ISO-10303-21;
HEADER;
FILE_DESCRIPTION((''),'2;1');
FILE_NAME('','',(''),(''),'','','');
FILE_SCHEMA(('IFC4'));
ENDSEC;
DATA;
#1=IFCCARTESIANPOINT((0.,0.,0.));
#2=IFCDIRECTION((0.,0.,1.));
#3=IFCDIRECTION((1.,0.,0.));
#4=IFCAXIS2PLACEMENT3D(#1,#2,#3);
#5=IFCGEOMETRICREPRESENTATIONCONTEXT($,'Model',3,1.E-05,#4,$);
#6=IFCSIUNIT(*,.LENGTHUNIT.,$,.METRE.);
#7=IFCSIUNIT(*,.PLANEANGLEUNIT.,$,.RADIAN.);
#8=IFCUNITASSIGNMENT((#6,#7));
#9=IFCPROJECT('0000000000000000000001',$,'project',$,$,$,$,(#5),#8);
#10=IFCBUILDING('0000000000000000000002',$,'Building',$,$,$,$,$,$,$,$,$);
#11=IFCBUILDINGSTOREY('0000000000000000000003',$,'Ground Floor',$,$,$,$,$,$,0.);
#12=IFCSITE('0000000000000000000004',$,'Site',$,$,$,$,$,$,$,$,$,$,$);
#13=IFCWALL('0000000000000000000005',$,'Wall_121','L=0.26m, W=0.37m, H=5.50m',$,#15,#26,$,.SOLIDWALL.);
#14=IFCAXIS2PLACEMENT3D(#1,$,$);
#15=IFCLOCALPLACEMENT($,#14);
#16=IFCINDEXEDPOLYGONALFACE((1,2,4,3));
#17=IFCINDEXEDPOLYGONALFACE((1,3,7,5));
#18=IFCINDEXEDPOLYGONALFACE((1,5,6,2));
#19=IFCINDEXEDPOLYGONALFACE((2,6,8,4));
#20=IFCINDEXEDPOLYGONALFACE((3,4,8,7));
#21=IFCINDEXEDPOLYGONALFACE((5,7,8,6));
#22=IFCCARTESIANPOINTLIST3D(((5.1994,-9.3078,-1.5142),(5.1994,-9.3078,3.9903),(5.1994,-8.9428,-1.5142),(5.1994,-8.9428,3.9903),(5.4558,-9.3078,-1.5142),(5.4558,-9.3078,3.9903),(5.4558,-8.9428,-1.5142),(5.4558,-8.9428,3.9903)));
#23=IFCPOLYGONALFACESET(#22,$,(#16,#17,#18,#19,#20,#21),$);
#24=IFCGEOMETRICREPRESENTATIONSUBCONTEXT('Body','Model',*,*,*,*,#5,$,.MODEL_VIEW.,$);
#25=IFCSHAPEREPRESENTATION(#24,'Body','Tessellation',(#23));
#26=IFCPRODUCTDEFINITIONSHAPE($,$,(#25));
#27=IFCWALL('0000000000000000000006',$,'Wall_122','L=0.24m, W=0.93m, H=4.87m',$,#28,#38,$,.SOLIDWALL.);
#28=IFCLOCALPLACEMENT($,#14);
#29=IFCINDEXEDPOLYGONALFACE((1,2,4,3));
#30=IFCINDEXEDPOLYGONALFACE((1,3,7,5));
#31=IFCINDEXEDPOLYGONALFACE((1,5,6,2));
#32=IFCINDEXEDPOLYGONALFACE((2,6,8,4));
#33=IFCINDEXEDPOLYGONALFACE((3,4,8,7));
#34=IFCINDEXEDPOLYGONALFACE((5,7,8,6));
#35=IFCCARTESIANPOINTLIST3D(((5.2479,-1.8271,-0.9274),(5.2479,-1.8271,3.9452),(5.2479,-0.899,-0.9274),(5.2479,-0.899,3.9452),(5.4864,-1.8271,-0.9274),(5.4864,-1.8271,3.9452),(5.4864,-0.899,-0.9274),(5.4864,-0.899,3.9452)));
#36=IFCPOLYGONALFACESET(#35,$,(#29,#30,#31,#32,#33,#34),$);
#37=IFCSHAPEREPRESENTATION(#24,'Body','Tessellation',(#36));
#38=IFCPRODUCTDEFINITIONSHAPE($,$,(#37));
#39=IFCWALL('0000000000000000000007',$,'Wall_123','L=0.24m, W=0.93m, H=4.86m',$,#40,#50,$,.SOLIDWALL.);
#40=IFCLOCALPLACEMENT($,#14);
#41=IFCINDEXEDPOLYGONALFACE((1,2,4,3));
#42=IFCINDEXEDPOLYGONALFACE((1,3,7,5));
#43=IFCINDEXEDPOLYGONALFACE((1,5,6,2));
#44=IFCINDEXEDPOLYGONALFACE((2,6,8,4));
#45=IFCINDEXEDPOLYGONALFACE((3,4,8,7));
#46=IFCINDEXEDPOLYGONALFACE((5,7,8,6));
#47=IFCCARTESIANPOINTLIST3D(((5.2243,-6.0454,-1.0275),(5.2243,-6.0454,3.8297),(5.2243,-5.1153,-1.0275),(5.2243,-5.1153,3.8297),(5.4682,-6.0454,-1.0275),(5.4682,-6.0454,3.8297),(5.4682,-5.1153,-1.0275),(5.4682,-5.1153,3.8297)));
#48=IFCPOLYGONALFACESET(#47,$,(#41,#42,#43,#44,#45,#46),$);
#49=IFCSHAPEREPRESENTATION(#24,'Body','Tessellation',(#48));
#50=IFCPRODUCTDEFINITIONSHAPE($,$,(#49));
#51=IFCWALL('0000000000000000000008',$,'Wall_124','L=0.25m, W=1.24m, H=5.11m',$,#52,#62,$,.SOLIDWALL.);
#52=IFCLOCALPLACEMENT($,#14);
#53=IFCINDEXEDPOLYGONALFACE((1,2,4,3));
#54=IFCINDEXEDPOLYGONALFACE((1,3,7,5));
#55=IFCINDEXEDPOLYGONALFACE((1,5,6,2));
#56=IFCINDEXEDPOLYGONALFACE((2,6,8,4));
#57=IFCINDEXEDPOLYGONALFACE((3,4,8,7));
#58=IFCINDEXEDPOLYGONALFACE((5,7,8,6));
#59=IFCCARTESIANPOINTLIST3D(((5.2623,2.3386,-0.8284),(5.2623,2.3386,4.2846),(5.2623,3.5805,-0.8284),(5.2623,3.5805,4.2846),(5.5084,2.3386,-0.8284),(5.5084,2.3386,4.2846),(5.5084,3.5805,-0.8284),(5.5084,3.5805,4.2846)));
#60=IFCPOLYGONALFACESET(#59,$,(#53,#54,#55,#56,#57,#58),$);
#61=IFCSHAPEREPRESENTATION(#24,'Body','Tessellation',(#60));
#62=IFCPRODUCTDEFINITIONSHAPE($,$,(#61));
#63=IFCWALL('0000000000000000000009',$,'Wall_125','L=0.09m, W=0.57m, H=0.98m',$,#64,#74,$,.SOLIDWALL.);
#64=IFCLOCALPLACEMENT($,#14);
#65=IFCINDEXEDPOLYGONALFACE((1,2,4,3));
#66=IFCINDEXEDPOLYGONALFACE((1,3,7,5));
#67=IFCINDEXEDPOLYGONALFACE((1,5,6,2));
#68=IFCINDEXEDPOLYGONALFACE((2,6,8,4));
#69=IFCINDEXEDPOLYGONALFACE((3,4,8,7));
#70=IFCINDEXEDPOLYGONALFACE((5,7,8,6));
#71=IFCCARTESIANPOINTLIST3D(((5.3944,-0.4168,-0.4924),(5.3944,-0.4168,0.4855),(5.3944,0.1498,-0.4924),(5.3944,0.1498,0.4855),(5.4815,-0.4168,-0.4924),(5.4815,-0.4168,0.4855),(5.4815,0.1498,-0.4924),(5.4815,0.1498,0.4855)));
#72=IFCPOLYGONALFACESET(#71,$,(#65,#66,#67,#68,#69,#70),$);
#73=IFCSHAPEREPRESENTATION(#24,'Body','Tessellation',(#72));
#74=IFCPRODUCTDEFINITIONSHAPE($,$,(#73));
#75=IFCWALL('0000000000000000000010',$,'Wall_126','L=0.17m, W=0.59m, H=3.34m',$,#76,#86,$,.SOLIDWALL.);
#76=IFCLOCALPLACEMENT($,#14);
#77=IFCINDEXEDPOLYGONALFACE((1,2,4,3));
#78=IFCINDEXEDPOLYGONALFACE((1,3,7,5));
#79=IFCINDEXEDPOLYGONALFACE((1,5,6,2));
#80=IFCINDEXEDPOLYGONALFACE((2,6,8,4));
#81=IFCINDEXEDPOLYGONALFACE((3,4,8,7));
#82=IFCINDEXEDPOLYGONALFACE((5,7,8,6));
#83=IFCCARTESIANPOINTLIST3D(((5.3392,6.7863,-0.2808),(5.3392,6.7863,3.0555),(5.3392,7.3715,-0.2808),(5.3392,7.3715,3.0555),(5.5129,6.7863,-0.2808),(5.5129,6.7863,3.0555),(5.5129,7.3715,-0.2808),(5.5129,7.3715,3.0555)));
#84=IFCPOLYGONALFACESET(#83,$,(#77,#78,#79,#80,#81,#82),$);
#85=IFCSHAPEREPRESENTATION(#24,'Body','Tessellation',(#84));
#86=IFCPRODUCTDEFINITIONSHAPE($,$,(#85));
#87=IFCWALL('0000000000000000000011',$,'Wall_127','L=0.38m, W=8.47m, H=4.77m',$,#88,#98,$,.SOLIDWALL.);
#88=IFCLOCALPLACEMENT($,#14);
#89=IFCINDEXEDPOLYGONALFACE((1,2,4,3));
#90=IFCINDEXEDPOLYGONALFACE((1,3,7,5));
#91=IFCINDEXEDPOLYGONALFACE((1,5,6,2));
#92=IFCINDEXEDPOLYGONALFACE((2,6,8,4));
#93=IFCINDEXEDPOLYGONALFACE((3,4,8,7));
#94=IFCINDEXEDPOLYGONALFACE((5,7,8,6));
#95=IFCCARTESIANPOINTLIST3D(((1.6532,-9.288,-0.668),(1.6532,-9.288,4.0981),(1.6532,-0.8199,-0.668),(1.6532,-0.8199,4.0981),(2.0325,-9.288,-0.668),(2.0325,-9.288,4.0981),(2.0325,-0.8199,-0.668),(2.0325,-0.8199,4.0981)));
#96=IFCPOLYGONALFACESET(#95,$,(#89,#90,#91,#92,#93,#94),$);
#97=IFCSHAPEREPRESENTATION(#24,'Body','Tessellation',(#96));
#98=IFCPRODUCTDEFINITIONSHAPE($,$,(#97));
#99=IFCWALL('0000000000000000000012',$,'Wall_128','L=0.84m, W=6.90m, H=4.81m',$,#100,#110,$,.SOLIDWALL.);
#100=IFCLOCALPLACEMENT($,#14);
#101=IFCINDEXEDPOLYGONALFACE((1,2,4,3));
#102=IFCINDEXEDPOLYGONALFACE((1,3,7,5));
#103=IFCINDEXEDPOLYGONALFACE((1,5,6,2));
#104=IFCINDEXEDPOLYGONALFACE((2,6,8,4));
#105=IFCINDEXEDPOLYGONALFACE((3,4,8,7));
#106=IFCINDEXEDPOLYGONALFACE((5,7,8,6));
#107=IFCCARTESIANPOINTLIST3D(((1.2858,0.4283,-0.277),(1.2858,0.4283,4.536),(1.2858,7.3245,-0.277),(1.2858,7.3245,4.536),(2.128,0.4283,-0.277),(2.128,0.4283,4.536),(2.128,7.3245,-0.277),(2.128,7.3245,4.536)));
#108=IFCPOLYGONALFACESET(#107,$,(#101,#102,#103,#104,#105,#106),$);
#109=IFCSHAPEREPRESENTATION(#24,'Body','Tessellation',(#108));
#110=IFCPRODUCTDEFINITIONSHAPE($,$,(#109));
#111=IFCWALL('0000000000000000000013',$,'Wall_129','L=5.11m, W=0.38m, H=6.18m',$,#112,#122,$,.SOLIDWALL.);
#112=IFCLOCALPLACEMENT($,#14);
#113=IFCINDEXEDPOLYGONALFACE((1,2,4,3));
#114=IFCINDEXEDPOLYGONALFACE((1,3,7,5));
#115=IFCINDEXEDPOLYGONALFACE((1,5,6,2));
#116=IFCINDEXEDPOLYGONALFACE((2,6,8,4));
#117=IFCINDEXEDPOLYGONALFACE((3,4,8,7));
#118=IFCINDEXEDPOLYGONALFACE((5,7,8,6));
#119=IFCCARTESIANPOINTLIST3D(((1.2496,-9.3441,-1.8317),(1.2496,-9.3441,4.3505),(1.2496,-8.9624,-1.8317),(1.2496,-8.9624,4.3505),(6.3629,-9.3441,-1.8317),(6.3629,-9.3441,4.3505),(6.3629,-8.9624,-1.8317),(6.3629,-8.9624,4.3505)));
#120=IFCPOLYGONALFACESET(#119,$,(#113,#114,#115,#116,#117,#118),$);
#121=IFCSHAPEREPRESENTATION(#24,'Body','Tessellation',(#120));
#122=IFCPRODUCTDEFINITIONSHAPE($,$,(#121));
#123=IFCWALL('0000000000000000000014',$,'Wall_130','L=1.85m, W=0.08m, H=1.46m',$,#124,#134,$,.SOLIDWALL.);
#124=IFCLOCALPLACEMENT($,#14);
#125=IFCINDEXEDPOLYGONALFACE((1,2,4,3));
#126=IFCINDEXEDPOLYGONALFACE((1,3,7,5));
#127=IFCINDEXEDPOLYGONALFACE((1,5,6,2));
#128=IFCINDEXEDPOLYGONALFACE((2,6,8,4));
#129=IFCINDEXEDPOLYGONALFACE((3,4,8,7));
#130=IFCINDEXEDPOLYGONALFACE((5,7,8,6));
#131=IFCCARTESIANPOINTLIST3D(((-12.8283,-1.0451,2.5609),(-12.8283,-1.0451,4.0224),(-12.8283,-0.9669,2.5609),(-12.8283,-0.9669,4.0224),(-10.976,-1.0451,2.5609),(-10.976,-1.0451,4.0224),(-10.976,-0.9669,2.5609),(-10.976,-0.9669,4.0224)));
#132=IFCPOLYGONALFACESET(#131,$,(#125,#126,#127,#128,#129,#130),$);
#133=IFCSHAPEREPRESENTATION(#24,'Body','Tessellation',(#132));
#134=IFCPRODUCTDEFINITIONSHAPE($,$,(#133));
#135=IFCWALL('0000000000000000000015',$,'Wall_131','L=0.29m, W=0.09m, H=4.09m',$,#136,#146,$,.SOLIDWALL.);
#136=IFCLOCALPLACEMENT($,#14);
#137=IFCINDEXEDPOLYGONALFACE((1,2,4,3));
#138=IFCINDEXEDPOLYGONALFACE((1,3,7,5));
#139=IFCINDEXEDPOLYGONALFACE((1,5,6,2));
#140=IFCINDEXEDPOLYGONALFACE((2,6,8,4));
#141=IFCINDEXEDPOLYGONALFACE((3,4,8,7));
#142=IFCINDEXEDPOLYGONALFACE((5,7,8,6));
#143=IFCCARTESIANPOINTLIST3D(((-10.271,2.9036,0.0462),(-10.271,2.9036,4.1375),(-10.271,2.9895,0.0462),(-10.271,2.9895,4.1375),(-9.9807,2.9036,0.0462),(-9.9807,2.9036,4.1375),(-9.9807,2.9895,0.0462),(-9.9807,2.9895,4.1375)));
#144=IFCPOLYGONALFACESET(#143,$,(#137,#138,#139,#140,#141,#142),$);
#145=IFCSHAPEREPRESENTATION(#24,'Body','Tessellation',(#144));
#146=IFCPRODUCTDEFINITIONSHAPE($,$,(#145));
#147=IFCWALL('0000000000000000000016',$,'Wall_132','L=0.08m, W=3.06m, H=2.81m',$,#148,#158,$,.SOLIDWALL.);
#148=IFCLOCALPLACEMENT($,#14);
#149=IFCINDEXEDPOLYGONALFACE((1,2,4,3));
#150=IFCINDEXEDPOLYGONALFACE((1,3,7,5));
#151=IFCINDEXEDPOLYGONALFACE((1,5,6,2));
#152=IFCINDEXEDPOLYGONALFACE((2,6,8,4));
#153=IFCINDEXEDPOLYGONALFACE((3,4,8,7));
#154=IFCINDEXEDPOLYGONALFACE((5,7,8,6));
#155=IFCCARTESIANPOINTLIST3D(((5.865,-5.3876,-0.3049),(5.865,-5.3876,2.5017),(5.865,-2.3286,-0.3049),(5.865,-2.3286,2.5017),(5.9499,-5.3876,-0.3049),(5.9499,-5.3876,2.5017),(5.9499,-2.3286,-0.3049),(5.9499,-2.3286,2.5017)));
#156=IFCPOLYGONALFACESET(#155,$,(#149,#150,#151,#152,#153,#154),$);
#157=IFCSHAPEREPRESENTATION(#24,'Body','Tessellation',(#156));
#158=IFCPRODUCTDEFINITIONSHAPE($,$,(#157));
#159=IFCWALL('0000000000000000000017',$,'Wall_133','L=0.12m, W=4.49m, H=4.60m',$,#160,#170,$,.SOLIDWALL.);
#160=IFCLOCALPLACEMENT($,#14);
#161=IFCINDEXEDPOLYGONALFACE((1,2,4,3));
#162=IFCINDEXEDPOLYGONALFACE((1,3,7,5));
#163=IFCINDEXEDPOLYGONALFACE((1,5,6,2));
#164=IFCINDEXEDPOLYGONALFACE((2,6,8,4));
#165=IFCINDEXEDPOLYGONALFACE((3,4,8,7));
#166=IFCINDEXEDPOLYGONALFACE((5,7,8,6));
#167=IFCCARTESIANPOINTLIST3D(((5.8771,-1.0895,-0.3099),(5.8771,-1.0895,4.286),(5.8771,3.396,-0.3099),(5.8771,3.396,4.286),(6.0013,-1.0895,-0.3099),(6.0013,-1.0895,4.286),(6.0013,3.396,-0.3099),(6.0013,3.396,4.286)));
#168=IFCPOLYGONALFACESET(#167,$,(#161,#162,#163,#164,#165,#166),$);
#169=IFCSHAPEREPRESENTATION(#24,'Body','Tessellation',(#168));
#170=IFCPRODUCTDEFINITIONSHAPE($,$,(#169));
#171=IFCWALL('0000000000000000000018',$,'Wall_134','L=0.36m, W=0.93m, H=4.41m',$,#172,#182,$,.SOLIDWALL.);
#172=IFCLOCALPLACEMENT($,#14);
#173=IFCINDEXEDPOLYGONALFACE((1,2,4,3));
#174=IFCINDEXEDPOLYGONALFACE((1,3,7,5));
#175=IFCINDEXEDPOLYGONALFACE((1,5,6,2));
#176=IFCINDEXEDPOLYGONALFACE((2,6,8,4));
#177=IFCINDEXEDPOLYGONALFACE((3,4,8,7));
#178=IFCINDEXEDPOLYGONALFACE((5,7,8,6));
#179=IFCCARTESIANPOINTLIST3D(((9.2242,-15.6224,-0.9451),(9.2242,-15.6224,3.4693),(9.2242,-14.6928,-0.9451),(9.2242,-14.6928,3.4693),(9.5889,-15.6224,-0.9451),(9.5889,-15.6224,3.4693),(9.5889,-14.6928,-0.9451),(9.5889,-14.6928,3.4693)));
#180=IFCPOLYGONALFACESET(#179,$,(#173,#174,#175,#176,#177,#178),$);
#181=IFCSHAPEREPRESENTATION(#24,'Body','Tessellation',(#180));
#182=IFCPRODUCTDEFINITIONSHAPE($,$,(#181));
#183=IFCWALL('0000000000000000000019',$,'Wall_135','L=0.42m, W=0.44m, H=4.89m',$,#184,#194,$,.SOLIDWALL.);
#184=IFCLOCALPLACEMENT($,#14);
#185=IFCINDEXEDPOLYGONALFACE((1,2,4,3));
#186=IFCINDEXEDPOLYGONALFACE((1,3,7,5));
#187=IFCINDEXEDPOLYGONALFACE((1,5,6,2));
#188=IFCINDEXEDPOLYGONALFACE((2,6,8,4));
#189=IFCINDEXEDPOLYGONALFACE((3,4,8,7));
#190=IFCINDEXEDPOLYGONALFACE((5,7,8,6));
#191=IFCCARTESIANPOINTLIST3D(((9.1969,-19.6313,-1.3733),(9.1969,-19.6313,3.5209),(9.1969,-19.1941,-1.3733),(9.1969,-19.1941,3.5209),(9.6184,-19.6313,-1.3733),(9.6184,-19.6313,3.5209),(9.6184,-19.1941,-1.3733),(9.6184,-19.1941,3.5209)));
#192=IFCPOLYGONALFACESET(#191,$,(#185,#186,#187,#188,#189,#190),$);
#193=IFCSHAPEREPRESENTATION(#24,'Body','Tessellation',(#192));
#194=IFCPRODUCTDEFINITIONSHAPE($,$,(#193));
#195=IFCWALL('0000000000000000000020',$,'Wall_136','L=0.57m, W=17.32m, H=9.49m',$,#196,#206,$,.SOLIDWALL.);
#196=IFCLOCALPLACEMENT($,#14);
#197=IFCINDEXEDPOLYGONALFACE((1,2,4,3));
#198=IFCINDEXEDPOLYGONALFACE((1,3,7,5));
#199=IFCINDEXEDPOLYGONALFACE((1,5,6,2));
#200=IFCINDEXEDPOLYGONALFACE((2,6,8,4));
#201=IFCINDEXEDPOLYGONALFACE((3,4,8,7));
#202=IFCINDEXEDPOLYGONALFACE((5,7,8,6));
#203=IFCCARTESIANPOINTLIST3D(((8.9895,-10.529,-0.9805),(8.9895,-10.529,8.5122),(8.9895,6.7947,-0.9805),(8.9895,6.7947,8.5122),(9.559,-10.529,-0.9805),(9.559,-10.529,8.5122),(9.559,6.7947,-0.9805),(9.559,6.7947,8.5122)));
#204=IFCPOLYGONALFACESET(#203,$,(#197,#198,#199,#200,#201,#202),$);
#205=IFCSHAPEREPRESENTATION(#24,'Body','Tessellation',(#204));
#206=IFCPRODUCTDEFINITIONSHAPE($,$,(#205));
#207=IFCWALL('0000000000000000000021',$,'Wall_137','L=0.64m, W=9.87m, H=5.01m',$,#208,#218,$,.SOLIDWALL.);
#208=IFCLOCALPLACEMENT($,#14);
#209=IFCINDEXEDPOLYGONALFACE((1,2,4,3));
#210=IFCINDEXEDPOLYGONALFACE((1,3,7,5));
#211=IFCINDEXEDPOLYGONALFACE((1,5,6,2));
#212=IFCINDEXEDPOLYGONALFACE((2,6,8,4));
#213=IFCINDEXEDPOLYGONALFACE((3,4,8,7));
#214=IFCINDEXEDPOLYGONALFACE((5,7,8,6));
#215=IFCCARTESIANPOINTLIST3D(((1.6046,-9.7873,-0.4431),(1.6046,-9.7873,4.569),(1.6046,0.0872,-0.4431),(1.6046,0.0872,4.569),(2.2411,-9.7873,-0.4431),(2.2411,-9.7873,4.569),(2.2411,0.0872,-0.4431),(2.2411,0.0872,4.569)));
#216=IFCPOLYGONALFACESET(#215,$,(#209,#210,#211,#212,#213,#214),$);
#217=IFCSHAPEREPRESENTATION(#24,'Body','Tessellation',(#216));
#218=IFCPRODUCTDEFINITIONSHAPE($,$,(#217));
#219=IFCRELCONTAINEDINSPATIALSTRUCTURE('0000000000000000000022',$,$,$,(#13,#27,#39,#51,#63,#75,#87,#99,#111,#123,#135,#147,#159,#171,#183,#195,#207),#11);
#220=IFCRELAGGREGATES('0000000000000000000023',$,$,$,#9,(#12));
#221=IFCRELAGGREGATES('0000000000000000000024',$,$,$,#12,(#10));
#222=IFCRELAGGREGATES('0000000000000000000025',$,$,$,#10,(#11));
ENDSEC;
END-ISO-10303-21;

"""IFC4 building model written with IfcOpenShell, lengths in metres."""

from ifc_helpers import new_model, si_unit, frame, origin_with_axes, origin_2d, context, subcontext, project, spatial, rectangle, extrude, element, save


model = new_model("IFC4")

# Units and contexts
model_context = context("Model", 3, precision=1e-05, world=origin_with_axes())
body_context = subcontext(model_context, "Body", "Model", "MODEL_VIEW")
ifc_project = project(units=[si_unit("LENGTHUNIT", "METRE"), si_unit("PLANEANGLEUNIT", "RADIAN")], contexts=[model_context])

# Site, building, storey
site = spatial("IfcSite", under=ifc_project, Name="Site")
building = spatial("IfcBuilding", under=site, Name="Building")
storey = spatial("IfcBuildingStorey", under=building, Name="Ground Floor", Elevation=0.0)

# Walls
element("IfcWall", 1, inside=storey, Name="Wall_121", Description="L=0.26m, W=0.37m, H=5.50m", PredefinedType="SOLIDWALL", context=body_context, shape_type="SweptSolid", body=[
    extrude(rectangle(XDim=0.2563, YDim=0.365, at=origin_2d()), frame((5.3276, -9.1253, -1.5142), z_axis=(0.0, 0.0, 1.0), x_axis=(1.0, 0.0, 0.0)), (0.0, 0.0, 1.0), 5.5045),
])
element("IfcWall", 2, inside=storey, Name="Wall_122", Description="L=0.24m, W=0.93m, H=4.87m", PredefinedType="SOLIDWALL", context=body_context, shape_type="SweptSolid", body=[
    extrude(rectangle(XDim=0.2385, YDim=0.9281, at=origin_2d()), frame((5.3671, -1.3631, -0.9274), z_axis=(0.0, 0.0, 1.0), x_axis=(1.0, 0.0, 0.0)), (0.0, 0.0, 1.0), 4.8725),
])
element("IfcWall", 3, inside=storey, Name="Wall_123", Description="L=0.24m, W=0.93m, H=4.86m", PredefinedType="SOLIDWALL", context=body_context, shape_type="SweptSolid", body=[
    extrude(rectangle(XDim=0.2439, YDim=0.9301, at=origin_2d()), frame((5.3463, -5.5804, -1.0275), z_axis=(0.0, 0.0, 1.0), x_axis=(1.0, 0.0, 0.0)), (0.0, 0.0, 1.0), 4.8572),
])
element("IfcWall", 4, inside=storey, Name="Wall_124", Description="L=0.25m, W=1.24m, H=5.11m", PredefinedType="SOLIDWALL", context=body_context, shape_type="SweptSolid", body=[
    extrude(rectangle(XDim=0.2461, YDim=1.2418, at=origin_2d()), frame((5.3853, 2.9595, -0.8284), z_axis=(0.0, 0.0, 1.0), x_axis=(1.0, 0.0, 0.0)), (0.0, 0.0, 1.0), 5.113),
])
element("IfcWall", 5, inside=storey, Name="Wall_125", Description="L=0.09m, W=0.57m, H=0.98m", PredefinedType="SOLIDWALL", context=body_context, shape_type="SweptSolid", body=[
    extrude(rectangle(XDim=0.0871, YDim=0.5666, at=origin_2d()), frame((5.438, -0.1335, -0.4924), z_axis=(0.0, 0.0, 1.0), x_axis=(1.0, 0.0, 0.0)), (0.0, 0.0, 1.0), 0.9779),
])
element("IfcWall", 6, inside=storey, Name="Wall_126", Description="L=0.17m, W=0.59m, H=3.34m", PredefinedType="SOLIDWALL", context=body_context, shape_type="SweptSolid", body=[
    extrude(rectangle(XDim=0.1738, YDim=0.5852, at=origin_2d()), frame((5.4261, 7.0789, -0.2808), z_axis=(0.0, 0.0, 1.0), x_axis=(1.0, 0.0, 0.0)), (0.0, 0.0, 1.0), 3.3363),
])
element("IfcWall", 7, inside=storey, Name="Wall_127", Description="L=0.38m, W=8.47m, H=4.77m", PredefinedType="SOLIDWALL", context=body_context, shape_type="SweptSolid", body=[
    extrude(rectangle(XDim=0.3793, YDim=8.4681, at=origin_2d()), frame((1.8429, -5.054, -0.668), z_axis=(0.0, 0.0, 1.0), x_axis=(1.0, 0.0, 0.0)), (0.0, 0.0, 1.0), 4.7661),
])
element("IfcWall", 8, inside=storey, Name="Wall_128", Description="L=0.84m, W=6.90m, H=4.81m", PredefinedType="SOLIDWALL", context=body_context, shape_type="SweptSolid", body=[
    extrude(rectangle(XDim=0.8422, YDim=6.8962, at=origin_2d()), frame((1.7069, 3.8764, -0.277), z_axis=(0.0, 0.0, 1.0), x_axis=(1.0, 0.0, 0.0)), (0.0, 0.0, 1.0), 4.8129),
])
element("IfcWall", 9, inside=storey, Name="Wall_129", Description="L=5.11m, W=0.38m, H=6.18m", PredefinedType="SOLIDWALL", context=body_context, shape_type="SweptSolid", body=[
    extrude(rectangle(XDim=5.1133, YDim=0.3817, at=origin_2d()), frame((3.8063, -9.1532, -1.8317), z_axis=(0.0, 0.0, 1.0), x_axis=(1.0, 0.0, 0.0)), (0.0, 0.0, 1.0), 6.1822),
])
element("IfcWall", 10, inside=storey, Name="Wall_130", Description="L=1.85m, W=0.08m, H=1.46m", PredefinedType="SOLIDWALL", context=body_context, shape_type="SweptSolid", body=[
    extrude(rectangle(XDim=1.8523, YDim=0.0783, at=origin_2d()), frame((-11.9021, -1.006, 2.5609), z_axis=(0.0, 0.0, 1.0), x_axis=(1.0, 0.0, 0.0)), (0.0, 0.0, 1.0), 1.4615),
])
element("IfcWall", 11, inside=storey, Name="Wall_131", Description="L=0.29m, W=0.09m, H=4.09m", PredefinedType="SOLIDWALL", context=body_context, shape_type="SweptSolid", body=[
    extrude(rectangle(XDim=0.2903, YDim=0.0859, at=origin_2d()), frame((-10.1258, 2.9466, 0.0462), z_axis=(0.0, 0.0, 1.0), x_axis=(1.0, 0.0, 0.0)), (0.0, 0.0, 1.0), 4.0912),
])
element("IfcWall", 12, inside=storey, Name="Wall_132", Description="L=0.08m, W=3.06m, H=2.81m", PredefinedType="SOLIDWALL", context=body_context, shape_type="SweptSolid", body=[
    extrude(rectangle(XDim=0.0849, YDim=3.059, at=origin_2d()), frame((5.9074, -3.8581, -0.3049), z_axis=(0.0, 0.0, 1.0), x_axis=(1.0, 0.0, 0.0)), (0.0, 0.0, 1.0), 2.8066),
])
element("IfcWall", 13, inside=storey, Name="Wall_133", Description="L=0.12m, W=4.49m, H=4.60m", PredefinedType="SOLIDWALL", context=body_context, shape_type="SweptSolid", body=[
    extrude(rectangle(XDim=0.1242, YDim=4.4854, at=origin_2d()), frame((5.9392, 1.1533, -0.3099), z_axis=(0.0, 0.0, 1.0), x_axis=(1.0, 0.0, 0.0)), (0.0, 0.0, 1.0), 4.5959),
])
element("IfcWall", 14, inside=storey, Name="Wall_134", Description="L=0.36m, W=0.93m, H=4.41m", PredefinedType="SOLIDWALL", context=body_context, shape_type="SweptSolid", body=[
    extrude(rectangle(XDim=0.3647, YDim=0.9296, at=origin_2d()), frame((9.4065, -15.1576, -0.9451), z_axis=(0.0, 0.0, 1.0), x_axis=(1.0, 0.0, 0.0)), (0.0, 0.0, 1.0), 4.4145),
])
element("IfcWall", 15, inside=storey, Name="Wall_135", Description="L=0.42m, W=0.44m, H=4.89m", PredefinedType="SOLIDWALL", context=body_context, shape_type="SweptSolid", body=[
    extrude(rectangle(XDim=0.4215, YDim=0.4372, at=origin_2d()), frame((9.4076, -19.4127, -1.3733), z_axis=(0.0, 0.0, 1.0), x_axis=(1.0, 0.0, 0.0)), (0.0, 0.0, 1.0), 4.8942),
])
element("IfcWall", 16, inside=storey, Name="Wall_136", Description="L=0.57m, W=17.32m, H=9.49m", PredefinedType="SOLIDWALL", context=body_context, shape_type="SweptSolid", body=[
    extrude(rectangle(XDim=0.5695, YDim=17.3237, at=origin_2d()), frame((9.2742, -1.8671, -0.9805), z_axis=(0.0, 0.0, 1.0), x_axis=(1.0, 0.0, 0.0)), (0.0, 0.0, 1.0), 9.4927),
])
element("IfcWall", 17, inside=storey, Name="Wall_137", Description="L=0.64m, W=9.87m, H=5.01m", PredefinedType="SOLIDWALL", context=body_context, shape_type="SweptSolid", body=[
    extrude(rectangle(XDim=0.6365, YDim=9.8745, at=origin_2d()), frame((1.9229, -4.8501, -0.4431), z_axis=(0.0, 0.0, 1.0), x_axis=(1.0, 0.0, 0.0)), (0.0, 0.0, 1.0), 5.0121),
])

save(model, "model.ifc")
